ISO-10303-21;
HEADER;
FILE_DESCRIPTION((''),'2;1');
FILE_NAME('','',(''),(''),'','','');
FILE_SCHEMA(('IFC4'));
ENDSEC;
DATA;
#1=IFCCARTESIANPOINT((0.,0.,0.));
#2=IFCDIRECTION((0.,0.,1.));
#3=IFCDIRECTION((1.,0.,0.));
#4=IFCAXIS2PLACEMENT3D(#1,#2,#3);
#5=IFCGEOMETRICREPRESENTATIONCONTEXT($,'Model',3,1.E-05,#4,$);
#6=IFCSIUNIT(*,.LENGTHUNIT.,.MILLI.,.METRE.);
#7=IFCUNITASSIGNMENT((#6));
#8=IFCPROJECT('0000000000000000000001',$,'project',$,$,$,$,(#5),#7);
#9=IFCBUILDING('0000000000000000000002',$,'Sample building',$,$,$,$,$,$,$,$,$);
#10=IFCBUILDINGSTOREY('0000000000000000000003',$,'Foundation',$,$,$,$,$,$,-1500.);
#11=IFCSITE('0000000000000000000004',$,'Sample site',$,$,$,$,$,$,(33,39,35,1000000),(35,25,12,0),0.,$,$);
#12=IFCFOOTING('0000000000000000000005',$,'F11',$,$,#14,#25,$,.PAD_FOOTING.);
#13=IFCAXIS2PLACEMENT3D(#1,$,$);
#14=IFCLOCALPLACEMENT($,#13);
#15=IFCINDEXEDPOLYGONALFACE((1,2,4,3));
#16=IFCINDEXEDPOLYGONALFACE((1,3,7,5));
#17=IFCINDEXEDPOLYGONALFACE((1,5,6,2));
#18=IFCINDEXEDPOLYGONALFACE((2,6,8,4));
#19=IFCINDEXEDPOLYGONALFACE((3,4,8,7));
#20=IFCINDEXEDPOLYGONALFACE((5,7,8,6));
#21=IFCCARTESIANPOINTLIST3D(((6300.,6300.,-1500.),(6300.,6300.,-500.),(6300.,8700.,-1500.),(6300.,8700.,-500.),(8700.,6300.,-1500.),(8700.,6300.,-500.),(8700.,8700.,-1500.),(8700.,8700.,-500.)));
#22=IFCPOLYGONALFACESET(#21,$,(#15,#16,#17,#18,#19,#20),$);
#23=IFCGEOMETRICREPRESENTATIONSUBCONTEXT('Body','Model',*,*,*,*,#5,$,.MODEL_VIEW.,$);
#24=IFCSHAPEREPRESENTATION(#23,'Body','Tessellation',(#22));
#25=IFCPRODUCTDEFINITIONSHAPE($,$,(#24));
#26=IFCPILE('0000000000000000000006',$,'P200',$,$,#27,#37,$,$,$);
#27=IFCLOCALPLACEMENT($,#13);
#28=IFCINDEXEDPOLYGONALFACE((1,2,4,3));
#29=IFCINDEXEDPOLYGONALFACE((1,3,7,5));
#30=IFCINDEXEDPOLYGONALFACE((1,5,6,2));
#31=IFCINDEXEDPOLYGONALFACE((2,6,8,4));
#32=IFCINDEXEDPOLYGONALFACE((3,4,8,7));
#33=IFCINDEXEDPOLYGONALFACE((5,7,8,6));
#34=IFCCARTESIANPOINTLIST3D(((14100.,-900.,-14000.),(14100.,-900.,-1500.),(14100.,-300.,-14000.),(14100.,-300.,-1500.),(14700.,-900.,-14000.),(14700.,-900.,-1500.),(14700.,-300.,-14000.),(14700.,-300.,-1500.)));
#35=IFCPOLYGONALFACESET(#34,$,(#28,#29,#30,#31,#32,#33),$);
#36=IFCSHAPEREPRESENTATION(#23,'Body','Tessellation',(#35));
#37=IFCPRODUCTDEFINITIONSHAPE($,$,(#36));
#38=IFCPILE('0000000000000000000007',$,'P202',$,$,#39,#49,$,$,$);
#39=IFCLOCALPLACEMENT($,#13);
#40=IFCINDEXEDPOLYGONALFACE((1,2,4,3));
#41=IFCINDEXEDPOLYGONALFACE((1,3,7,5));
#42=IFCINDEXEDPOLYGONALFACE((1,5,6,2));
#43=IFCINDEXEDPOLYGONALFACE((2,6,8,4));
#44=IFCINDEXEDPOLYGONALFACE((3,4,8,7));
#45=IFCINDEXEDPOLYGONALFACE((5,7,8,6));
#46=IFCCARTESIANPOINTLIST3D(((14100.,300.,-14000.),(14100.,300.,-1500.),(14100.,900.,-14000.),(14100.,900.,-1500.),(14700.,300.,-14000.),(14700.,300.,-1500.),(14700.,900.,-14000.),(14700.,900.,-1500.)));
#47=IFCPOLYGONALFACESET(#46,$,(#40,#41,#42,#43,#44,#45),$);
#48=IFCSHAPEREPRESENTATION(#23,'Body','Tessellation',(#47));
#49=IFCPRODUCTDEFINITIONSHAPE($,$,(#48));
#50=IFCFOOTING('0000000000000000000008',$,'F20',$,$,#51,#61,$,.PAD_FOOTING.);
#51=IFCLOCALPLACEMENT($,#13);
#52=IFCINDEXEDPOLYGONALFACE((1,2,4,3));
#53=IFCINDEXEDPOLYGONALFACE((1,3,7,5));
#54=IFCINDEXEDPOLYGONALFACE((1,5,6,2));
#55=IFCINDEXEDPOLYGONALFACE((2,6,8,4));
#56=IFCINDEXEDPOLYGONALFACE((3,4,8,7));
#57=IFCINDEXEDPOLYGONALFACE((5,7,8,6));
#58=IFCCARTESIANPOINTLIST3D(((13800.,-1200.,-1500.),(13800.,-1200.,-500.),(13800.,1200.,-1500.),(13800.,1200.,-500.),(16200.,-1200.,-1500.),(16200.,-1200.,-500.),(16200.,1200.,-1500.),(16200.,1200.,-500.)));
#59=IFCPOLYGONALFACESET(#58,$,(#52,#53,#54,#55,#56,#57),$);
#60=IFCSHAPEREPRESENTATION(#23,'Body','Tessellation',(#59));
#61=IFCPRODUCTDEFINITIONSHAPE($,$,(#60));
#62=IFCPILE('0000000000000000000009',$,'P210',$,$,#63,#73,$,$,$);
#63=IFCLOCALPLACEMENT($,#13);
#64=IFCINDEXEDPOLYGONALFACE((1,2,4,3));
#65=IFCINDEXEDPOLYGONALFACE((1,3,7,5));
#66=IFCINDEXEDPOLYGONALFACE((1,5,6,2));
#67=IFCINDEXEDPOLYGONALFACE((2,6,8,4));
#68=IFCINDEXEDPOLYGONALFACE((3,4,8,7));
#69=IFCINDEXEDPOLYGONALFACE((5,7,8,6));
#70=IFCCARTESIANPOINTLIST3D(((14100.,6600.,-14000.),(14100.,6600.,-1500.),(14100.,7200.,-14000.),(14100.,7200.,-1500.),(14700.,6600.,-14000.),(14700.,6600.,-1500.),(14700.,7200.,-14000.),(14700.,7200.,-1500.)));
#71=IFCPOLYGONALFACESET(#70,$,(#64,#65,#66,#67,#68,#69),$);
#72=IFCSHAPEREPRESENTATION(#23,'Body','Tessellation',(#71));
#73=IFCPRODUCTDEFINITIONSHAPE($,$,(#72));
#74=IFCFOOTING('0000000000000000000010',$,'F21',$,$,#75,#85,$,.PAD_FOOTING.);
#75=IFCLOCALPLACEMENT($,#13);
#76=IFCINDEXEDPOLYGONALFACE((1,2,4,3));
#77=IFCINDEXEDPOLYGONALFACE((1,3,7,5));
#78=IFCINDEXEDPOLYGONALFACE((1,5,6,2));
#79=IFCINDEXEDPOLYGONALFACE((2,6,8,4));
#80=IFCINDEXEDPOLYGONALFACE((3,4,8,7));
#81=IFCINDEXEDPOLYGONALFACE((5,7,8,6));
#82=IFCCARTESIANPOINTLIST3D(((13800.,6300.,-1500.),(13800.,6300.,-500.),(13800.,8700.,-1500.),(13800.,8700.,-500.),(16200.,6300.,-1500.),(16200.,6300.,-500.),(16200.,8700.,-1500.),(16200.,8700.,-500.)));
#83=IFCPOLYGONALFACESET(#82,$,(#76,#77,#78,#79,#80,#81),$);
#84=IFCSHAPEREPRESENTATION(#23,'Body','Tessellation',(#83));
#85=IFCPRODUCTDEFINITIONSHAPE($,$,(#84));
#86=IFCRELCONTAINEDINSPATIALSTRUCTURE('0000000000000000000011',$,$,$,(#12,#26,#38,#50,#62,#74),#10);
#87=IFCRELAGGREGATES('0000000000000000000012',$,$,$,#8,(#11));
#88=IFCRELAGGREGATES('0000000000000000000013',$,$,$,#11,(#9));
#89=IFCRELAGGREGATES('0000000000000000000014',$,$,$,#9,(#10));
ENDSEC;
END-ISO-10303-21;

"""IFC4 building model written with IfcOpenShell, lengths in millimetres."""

from ifc_helpers import new_model, si_unit, frame, origin_with_axes, place, context, subcontext, project, spatial, indexed_curve, outline, extrude, element, save


model = new_model("IFC4")

# Units and contexts
model_context = context("Model", 3, precision=1e-05, world=origin_with_axes())
body_context = subcontext(model_context, "Body", "Model", "MODEL_VIEW")
ifc_project = project(units=[si_unit("LENGTHUNIT", "METRE", prefix="MILLI")], contexts=[model_context])

# Site, building, storey
site = spatial("IfcSite", under=ifc_project, Name="Sample site", RefLatitude=(33, 39, 35, 1000000), RefLongitude=(35, 25, 12, 0), RefElevation=0.0)
building = spatial("IfcBuilding", under=site, Name="Sample building")
storey = spatial("IfcBuildingStorey", under=building, Name="Foundation", Elevation=-1500.0)

# Footing
footing_1_placement = place(None, frame((6300.0, 6300.0, -1500.0), z_axis=(0.0, 0.0, 1.0), x_axis=(1.0, 0.0, 0.0)))
element("IfcFooting", 1, at=footing_1_placement, inside=storey, Name="F11", PredefinedType="PAD_FOOTING", context=body_context, shape_type="SweptSolid", body=[
    extrude(outline(indexed_curve([(0.0, 0.0), (0.0, 2400.0), (2400.0, 2400.0), (2400.0, 0.0), (0.0, 0.0)], self_intersect=False)), origin_with_axes(), (0.0, 0.0, 1.0), 1000.0),
])

# Piles
for number, where, z_axis, x_axis, name in (
    (2, (14100.0, -900.0, -14000.0), (0.0, 0.0, 1.0), (1.0, 0.0, 0.0), "P200"),
    (3, (14100.0, 300.0, -14000.0), (0.0, 0.0, 1.0), (1.0, 0.0, 0.0), "P202"),
):
    element("IfcPile", number, at=place(None, frame(where, z_axis=z_axis, x_axis=x_axis)), inside=storey, Name=name, context=body_context, shape_type="SweptSolid", body=[
        extrude(outline(indexed_curve([(0.0, 0.0), (0.0, 600.0), (600.0, 600.0), (600.0, 0.0), (0.0, 0.0)], self_intersect=False)), origin_with_axes(), (0.0, 0.0, 1.0), 12500.0),
    ])

# Footing
footing_2_placement = place(None, frame((13800.0, -1200.0, -1500.0), z_axis=(0.0, 0.0, 1.0), x_axis=(1.0, 0.0, 0.0)))
element("IfcFooting", 4, at=footing_2_placement, inside=storey, Name="F20", PredefinedType="PAD_FOOTING", context=body_context, shape_type="SweptSolid", body=[
    extrude(outline(indexed_curve([(0.0, 0.0), (0.0, 2400.0), (2400.0, 2400.0), (2400.0, 0.0), (0.0, 0.0)], self_intersect=False)), origin_with_axes(), (0.0, 0.0, 1.0), 1000.0),
])

# Pile
pile_placement = place(None, frame((14100.0, 6600.0, -14000.0), z_axis=(0.0, 0.0, 1.0), x_axis=(1.0, 0.0, 0.0)))
element("IfcPile", 5, at=pile_placement, inside=storey, Name="P210", context=body_context, shape_type="SweptSolid", body=[
    extrude(outline(indexed_curve([(0.0, 0.0), (0.0, 600.0), (600.0, 600.0), (600.0, 0.0), (0.0, 0.0)], self_intersect=False)), origin_with_axes(), (0.0, 0.0, 1.0), 12500.0),
])

# Footing
footing_3_placement = place(None, frame((13800.0, 6300.0, -1500.0), z_axis=(0.0, 0.0, 1.0), x_axis=(1.0, 0.0, 0.0)))
element("IfcFooting", 6, at=footing_3_placement, inside=storey, Name="F21", PredefinedType="PAD_FOOTING", context=body_context, shape_type="SweptSolid", body=[
    extrude(outline(indexed_curve([(0.0, 0.0), (0.0, 2400.0), (2400.0, 2400.0), (2400.0, 0.0), (0.0, 0.0)], self_intersect=False)), origin_with_axes(), (0.0, 0.0, 1.0), 1000.0),
])

save(model, "model.ifc")
